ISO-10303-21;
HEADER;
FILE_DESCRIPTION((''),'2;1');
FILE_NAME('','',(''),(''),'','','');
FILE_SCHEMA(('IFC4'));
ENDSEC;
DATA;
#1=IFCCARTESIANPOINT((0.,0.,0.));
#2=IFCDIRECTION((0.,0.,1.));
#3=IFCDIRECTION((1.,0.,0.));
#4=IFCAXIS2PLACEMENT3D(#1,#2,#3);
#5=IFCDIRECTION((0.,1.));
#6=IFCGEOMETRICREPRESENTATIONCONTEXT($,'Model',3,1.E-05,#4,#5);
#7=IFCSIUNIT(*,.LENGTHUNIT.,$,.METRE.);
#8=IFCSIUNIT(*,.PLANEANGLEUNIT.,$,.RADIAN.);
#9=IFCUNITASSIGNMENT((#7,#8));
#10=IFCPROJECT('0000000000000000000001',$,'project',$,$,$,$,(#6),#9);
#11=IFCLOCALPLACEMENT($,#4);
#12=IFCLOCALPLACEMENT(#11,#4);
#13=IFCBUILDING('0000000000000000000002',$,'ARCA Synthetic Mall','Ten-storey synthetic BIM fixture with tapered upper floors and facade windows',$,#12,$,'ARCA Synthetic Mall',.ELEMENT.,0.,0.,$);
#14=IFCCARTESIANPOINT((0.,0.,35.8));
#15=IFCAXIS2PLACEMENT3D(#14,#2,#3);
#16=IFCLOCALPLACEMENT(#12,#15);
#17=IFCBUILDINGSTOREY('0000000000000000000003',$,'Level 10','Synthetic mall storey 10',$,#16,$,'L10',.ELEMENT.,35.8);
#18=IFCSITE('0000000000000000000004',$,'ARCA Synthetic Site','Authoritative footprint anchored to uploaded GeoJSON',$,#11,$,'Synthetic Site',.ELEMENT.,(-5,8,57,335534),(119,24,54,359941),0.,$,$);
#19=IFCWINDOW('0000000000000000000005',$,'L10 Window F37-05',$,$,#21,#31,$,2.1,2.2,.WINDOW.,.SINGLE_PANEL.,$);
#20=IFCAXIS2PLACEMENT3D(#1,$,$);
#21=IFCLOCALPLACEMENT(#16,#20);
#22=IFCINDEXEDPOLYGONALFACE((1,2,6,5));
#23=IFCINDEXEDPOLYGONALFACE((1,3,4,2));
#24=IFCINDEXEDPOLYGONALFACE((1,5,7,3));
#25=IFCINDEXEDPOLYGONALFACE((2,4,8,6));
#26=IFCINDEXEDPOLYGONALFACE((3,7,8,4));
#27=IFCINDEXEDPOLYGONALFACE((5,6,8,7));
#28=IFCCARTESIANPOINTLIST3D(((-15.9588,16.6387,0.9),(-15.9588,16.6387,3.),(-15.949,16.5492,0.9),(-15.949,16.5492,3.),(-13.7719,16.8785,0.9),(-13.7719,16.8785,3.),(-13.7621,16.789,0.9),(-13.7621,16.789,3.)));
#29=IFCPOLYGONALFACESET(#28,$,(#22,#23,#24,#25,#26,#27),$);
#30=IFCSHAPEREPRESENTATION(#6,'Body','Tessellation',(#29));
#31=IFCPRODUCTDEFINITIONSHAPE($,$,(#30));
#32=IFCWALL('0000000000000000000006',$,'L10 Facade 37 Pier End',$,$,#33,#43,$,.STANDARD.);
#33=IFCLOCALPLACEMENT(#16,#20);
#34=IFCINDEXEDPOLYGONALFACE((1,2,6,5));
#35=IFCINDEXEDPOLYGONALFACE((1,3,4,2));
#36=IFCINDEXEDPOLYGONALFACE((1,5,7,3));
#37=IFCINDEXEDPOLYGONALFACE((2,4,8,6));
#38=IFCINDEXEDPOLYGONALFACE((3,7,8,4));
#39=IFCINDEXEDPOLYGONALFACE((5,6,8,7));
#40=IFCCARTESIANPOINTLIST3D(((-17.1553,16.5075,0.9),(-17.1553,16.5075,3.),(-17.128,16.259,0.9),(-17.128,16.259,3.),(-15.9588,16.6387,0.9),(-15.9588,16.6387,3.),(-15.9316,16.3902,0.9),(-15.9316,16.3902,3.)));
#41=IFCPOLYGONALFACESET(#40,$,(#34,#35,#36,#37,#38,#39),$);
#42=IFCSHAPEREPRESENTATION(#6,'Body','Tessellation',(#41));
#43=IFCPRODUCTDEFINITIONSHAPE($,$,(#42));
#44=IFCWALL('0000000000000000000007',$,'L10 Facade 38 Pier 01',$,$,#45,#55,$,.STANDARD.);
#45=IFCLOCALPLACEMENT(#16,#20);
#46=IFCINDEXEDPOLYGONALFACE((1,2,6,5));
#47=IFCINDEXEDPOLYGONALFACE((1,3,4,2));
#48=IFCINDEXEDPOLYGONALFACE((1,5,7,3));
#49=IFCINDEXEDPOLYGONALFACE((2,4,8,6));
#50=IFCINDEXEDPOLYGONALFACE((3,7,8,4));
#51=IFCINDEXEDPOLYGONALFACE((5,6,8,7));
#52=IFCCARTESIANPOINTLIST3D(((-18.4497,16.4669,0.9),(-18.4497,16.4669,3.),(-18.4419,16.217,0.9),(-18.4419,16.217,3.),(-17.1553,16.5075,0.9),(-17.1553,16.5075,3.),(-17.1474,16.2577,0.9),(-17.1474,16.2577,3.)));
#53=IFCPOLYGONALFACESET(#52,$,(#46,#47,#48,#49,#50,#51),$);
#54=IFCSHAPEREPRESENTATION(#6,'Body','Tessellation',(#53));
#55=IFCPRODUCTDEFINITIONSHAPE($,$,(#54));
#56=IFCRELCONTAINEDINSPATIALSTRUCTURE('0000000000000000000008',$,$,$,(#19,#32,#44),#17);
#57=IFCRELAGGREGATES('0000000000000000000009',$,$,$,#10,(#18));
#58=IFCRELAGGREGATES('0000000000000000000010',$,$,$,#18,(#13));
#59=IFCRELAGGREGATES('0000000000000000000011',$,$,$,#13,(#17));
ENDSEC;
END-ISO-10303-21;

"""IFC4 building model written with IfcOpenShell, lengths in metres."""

from ifc_helpers import new_model, si_unit, direction, frame, origin_with_axes, place, context, project, spatial, polyline, outline, extrude, element, save


model = new_model("IFC4")

# Units and contexts
model_context = context("Model", 3, precision=1e-05, world=origin_with_axes(), true_north=direction((0.0, 1.0)))
ifc_project = project(units=[si_unit("LENGTHUNIT", "METRE"), si_unit("PLANEANGLEUNIT", "RADIAN")], contexts=[model_context])

# Site, building, storey
site_placement = place(None, origin_with_axes())
site = spatial("IfcSite", under=ifc_project, at=site_placement, Name="ARCA Synthetic Site", Description="Authoritative footprint anchored to uploaded GeoJSON", LongName="Synthetic Site", CompositionType="ELEMENT", RefLatitude=(-5, 8, 57, 335534), RefLongitude=(119, 24, 54, 359941), RefElevation=0.0)
building_placement = place(site_placement, origin_with_axes())
building = spatial("IfcBuilding", under=site, at=building_placement, Name="ARCA Synthetic Mall", Description="Ten-storey synthetic BIM fixture with tapered upper floors and facade windows", LongName="ARCA Synthetic Mall", CompositionType="ELEMENT", ElevationOfRefHeight=0.0, ElevationOfTerrain=0.0)
storey_placement = place(building_placement, frame((0.0, 0.0, 35.8), z_axis=(0.0, 0.0, 1.0), x_axis=(1.0, 0.0, 0.0)))
storey = spatial("IfcBuildingStorey", under=building, at=storey_placement, Name="Level 10", Description="Synthetic mall storey 10", LongName="L10", CompositionType="ELEMENT", Elevation=35.8)

# Window
window_1_placement = place(storey_placement, frame((0.0, 0.0, 0.9), z_axis=(0.0, 0.0, 1.0), x_axis=(1.0, 0.0, 0.0)))
element("IfcWindow", 1, at=window_1_placement, inside=storey, Name="L10 Window F37-05", OverallHeight=2.1, OverallWidth=2.2, PartitioningType="SINGLE_PANEL", PredefinedType="WINDOW", context=model_context, shape_type="SweptSolid", body=[
    extrude(outline(polyline([(-13.7719, 16.8785), (-15.9588, 16.6387), (-15.949, 16.5492), (-13.7621, 16.789), (-13.7719, 16.8785)])), origin_with_axes(), (0.0, 0.0, 1.0), 2.1),
])

# Walls
wall_1_placement = place(storey_placement, frame((0.0, 0.0, 0.9), z_axis=(0.0, 0.0, 1.0), x_axis=(1.0, 0.0, 0.0)))
element("IfcWall", 2, at=wall_1_placement, inside=storey, Name="L10 Facade 37 Pier End", PredefinedType="STANDARD", context=model_context, shape_type="SweptSolid", body=[
    extrude(outline(polyline([(-15.9588, 16.6387), (-17.1553, 16.5075), (-17.128, 16.259), (-15.9316, 16.3902), (-15.9588, 16.6387)])), origin_with_axes(), (0.0, 0.0, 1.0), 2.1),
])
wall_2_placement = place(storey_placement, frame((0.0, 0.0, 0.9), z_axis=(0.0, 0.0, 1.0), x_axis=(1.0, 0.0, 0.0)))
element("IfcWall", 3, at=wall_2_placement, inside=storey, Name="L10 Facade 38 Pier 01", PredefinedType="STANDARD", context=model_context, shape_type="SweptSolid", body=[
    extrude(outline(polyline([(-17.1553, 16.5075), (-18.4497, 16.4669), (-18.4419, 16.217), (-17.1474, 16.2577), (-17.1553, 16.5075)])), origin_with_axes(), (0.0, 0.0, 1.0), 2.1),
])

save(model, "model.ifc")
